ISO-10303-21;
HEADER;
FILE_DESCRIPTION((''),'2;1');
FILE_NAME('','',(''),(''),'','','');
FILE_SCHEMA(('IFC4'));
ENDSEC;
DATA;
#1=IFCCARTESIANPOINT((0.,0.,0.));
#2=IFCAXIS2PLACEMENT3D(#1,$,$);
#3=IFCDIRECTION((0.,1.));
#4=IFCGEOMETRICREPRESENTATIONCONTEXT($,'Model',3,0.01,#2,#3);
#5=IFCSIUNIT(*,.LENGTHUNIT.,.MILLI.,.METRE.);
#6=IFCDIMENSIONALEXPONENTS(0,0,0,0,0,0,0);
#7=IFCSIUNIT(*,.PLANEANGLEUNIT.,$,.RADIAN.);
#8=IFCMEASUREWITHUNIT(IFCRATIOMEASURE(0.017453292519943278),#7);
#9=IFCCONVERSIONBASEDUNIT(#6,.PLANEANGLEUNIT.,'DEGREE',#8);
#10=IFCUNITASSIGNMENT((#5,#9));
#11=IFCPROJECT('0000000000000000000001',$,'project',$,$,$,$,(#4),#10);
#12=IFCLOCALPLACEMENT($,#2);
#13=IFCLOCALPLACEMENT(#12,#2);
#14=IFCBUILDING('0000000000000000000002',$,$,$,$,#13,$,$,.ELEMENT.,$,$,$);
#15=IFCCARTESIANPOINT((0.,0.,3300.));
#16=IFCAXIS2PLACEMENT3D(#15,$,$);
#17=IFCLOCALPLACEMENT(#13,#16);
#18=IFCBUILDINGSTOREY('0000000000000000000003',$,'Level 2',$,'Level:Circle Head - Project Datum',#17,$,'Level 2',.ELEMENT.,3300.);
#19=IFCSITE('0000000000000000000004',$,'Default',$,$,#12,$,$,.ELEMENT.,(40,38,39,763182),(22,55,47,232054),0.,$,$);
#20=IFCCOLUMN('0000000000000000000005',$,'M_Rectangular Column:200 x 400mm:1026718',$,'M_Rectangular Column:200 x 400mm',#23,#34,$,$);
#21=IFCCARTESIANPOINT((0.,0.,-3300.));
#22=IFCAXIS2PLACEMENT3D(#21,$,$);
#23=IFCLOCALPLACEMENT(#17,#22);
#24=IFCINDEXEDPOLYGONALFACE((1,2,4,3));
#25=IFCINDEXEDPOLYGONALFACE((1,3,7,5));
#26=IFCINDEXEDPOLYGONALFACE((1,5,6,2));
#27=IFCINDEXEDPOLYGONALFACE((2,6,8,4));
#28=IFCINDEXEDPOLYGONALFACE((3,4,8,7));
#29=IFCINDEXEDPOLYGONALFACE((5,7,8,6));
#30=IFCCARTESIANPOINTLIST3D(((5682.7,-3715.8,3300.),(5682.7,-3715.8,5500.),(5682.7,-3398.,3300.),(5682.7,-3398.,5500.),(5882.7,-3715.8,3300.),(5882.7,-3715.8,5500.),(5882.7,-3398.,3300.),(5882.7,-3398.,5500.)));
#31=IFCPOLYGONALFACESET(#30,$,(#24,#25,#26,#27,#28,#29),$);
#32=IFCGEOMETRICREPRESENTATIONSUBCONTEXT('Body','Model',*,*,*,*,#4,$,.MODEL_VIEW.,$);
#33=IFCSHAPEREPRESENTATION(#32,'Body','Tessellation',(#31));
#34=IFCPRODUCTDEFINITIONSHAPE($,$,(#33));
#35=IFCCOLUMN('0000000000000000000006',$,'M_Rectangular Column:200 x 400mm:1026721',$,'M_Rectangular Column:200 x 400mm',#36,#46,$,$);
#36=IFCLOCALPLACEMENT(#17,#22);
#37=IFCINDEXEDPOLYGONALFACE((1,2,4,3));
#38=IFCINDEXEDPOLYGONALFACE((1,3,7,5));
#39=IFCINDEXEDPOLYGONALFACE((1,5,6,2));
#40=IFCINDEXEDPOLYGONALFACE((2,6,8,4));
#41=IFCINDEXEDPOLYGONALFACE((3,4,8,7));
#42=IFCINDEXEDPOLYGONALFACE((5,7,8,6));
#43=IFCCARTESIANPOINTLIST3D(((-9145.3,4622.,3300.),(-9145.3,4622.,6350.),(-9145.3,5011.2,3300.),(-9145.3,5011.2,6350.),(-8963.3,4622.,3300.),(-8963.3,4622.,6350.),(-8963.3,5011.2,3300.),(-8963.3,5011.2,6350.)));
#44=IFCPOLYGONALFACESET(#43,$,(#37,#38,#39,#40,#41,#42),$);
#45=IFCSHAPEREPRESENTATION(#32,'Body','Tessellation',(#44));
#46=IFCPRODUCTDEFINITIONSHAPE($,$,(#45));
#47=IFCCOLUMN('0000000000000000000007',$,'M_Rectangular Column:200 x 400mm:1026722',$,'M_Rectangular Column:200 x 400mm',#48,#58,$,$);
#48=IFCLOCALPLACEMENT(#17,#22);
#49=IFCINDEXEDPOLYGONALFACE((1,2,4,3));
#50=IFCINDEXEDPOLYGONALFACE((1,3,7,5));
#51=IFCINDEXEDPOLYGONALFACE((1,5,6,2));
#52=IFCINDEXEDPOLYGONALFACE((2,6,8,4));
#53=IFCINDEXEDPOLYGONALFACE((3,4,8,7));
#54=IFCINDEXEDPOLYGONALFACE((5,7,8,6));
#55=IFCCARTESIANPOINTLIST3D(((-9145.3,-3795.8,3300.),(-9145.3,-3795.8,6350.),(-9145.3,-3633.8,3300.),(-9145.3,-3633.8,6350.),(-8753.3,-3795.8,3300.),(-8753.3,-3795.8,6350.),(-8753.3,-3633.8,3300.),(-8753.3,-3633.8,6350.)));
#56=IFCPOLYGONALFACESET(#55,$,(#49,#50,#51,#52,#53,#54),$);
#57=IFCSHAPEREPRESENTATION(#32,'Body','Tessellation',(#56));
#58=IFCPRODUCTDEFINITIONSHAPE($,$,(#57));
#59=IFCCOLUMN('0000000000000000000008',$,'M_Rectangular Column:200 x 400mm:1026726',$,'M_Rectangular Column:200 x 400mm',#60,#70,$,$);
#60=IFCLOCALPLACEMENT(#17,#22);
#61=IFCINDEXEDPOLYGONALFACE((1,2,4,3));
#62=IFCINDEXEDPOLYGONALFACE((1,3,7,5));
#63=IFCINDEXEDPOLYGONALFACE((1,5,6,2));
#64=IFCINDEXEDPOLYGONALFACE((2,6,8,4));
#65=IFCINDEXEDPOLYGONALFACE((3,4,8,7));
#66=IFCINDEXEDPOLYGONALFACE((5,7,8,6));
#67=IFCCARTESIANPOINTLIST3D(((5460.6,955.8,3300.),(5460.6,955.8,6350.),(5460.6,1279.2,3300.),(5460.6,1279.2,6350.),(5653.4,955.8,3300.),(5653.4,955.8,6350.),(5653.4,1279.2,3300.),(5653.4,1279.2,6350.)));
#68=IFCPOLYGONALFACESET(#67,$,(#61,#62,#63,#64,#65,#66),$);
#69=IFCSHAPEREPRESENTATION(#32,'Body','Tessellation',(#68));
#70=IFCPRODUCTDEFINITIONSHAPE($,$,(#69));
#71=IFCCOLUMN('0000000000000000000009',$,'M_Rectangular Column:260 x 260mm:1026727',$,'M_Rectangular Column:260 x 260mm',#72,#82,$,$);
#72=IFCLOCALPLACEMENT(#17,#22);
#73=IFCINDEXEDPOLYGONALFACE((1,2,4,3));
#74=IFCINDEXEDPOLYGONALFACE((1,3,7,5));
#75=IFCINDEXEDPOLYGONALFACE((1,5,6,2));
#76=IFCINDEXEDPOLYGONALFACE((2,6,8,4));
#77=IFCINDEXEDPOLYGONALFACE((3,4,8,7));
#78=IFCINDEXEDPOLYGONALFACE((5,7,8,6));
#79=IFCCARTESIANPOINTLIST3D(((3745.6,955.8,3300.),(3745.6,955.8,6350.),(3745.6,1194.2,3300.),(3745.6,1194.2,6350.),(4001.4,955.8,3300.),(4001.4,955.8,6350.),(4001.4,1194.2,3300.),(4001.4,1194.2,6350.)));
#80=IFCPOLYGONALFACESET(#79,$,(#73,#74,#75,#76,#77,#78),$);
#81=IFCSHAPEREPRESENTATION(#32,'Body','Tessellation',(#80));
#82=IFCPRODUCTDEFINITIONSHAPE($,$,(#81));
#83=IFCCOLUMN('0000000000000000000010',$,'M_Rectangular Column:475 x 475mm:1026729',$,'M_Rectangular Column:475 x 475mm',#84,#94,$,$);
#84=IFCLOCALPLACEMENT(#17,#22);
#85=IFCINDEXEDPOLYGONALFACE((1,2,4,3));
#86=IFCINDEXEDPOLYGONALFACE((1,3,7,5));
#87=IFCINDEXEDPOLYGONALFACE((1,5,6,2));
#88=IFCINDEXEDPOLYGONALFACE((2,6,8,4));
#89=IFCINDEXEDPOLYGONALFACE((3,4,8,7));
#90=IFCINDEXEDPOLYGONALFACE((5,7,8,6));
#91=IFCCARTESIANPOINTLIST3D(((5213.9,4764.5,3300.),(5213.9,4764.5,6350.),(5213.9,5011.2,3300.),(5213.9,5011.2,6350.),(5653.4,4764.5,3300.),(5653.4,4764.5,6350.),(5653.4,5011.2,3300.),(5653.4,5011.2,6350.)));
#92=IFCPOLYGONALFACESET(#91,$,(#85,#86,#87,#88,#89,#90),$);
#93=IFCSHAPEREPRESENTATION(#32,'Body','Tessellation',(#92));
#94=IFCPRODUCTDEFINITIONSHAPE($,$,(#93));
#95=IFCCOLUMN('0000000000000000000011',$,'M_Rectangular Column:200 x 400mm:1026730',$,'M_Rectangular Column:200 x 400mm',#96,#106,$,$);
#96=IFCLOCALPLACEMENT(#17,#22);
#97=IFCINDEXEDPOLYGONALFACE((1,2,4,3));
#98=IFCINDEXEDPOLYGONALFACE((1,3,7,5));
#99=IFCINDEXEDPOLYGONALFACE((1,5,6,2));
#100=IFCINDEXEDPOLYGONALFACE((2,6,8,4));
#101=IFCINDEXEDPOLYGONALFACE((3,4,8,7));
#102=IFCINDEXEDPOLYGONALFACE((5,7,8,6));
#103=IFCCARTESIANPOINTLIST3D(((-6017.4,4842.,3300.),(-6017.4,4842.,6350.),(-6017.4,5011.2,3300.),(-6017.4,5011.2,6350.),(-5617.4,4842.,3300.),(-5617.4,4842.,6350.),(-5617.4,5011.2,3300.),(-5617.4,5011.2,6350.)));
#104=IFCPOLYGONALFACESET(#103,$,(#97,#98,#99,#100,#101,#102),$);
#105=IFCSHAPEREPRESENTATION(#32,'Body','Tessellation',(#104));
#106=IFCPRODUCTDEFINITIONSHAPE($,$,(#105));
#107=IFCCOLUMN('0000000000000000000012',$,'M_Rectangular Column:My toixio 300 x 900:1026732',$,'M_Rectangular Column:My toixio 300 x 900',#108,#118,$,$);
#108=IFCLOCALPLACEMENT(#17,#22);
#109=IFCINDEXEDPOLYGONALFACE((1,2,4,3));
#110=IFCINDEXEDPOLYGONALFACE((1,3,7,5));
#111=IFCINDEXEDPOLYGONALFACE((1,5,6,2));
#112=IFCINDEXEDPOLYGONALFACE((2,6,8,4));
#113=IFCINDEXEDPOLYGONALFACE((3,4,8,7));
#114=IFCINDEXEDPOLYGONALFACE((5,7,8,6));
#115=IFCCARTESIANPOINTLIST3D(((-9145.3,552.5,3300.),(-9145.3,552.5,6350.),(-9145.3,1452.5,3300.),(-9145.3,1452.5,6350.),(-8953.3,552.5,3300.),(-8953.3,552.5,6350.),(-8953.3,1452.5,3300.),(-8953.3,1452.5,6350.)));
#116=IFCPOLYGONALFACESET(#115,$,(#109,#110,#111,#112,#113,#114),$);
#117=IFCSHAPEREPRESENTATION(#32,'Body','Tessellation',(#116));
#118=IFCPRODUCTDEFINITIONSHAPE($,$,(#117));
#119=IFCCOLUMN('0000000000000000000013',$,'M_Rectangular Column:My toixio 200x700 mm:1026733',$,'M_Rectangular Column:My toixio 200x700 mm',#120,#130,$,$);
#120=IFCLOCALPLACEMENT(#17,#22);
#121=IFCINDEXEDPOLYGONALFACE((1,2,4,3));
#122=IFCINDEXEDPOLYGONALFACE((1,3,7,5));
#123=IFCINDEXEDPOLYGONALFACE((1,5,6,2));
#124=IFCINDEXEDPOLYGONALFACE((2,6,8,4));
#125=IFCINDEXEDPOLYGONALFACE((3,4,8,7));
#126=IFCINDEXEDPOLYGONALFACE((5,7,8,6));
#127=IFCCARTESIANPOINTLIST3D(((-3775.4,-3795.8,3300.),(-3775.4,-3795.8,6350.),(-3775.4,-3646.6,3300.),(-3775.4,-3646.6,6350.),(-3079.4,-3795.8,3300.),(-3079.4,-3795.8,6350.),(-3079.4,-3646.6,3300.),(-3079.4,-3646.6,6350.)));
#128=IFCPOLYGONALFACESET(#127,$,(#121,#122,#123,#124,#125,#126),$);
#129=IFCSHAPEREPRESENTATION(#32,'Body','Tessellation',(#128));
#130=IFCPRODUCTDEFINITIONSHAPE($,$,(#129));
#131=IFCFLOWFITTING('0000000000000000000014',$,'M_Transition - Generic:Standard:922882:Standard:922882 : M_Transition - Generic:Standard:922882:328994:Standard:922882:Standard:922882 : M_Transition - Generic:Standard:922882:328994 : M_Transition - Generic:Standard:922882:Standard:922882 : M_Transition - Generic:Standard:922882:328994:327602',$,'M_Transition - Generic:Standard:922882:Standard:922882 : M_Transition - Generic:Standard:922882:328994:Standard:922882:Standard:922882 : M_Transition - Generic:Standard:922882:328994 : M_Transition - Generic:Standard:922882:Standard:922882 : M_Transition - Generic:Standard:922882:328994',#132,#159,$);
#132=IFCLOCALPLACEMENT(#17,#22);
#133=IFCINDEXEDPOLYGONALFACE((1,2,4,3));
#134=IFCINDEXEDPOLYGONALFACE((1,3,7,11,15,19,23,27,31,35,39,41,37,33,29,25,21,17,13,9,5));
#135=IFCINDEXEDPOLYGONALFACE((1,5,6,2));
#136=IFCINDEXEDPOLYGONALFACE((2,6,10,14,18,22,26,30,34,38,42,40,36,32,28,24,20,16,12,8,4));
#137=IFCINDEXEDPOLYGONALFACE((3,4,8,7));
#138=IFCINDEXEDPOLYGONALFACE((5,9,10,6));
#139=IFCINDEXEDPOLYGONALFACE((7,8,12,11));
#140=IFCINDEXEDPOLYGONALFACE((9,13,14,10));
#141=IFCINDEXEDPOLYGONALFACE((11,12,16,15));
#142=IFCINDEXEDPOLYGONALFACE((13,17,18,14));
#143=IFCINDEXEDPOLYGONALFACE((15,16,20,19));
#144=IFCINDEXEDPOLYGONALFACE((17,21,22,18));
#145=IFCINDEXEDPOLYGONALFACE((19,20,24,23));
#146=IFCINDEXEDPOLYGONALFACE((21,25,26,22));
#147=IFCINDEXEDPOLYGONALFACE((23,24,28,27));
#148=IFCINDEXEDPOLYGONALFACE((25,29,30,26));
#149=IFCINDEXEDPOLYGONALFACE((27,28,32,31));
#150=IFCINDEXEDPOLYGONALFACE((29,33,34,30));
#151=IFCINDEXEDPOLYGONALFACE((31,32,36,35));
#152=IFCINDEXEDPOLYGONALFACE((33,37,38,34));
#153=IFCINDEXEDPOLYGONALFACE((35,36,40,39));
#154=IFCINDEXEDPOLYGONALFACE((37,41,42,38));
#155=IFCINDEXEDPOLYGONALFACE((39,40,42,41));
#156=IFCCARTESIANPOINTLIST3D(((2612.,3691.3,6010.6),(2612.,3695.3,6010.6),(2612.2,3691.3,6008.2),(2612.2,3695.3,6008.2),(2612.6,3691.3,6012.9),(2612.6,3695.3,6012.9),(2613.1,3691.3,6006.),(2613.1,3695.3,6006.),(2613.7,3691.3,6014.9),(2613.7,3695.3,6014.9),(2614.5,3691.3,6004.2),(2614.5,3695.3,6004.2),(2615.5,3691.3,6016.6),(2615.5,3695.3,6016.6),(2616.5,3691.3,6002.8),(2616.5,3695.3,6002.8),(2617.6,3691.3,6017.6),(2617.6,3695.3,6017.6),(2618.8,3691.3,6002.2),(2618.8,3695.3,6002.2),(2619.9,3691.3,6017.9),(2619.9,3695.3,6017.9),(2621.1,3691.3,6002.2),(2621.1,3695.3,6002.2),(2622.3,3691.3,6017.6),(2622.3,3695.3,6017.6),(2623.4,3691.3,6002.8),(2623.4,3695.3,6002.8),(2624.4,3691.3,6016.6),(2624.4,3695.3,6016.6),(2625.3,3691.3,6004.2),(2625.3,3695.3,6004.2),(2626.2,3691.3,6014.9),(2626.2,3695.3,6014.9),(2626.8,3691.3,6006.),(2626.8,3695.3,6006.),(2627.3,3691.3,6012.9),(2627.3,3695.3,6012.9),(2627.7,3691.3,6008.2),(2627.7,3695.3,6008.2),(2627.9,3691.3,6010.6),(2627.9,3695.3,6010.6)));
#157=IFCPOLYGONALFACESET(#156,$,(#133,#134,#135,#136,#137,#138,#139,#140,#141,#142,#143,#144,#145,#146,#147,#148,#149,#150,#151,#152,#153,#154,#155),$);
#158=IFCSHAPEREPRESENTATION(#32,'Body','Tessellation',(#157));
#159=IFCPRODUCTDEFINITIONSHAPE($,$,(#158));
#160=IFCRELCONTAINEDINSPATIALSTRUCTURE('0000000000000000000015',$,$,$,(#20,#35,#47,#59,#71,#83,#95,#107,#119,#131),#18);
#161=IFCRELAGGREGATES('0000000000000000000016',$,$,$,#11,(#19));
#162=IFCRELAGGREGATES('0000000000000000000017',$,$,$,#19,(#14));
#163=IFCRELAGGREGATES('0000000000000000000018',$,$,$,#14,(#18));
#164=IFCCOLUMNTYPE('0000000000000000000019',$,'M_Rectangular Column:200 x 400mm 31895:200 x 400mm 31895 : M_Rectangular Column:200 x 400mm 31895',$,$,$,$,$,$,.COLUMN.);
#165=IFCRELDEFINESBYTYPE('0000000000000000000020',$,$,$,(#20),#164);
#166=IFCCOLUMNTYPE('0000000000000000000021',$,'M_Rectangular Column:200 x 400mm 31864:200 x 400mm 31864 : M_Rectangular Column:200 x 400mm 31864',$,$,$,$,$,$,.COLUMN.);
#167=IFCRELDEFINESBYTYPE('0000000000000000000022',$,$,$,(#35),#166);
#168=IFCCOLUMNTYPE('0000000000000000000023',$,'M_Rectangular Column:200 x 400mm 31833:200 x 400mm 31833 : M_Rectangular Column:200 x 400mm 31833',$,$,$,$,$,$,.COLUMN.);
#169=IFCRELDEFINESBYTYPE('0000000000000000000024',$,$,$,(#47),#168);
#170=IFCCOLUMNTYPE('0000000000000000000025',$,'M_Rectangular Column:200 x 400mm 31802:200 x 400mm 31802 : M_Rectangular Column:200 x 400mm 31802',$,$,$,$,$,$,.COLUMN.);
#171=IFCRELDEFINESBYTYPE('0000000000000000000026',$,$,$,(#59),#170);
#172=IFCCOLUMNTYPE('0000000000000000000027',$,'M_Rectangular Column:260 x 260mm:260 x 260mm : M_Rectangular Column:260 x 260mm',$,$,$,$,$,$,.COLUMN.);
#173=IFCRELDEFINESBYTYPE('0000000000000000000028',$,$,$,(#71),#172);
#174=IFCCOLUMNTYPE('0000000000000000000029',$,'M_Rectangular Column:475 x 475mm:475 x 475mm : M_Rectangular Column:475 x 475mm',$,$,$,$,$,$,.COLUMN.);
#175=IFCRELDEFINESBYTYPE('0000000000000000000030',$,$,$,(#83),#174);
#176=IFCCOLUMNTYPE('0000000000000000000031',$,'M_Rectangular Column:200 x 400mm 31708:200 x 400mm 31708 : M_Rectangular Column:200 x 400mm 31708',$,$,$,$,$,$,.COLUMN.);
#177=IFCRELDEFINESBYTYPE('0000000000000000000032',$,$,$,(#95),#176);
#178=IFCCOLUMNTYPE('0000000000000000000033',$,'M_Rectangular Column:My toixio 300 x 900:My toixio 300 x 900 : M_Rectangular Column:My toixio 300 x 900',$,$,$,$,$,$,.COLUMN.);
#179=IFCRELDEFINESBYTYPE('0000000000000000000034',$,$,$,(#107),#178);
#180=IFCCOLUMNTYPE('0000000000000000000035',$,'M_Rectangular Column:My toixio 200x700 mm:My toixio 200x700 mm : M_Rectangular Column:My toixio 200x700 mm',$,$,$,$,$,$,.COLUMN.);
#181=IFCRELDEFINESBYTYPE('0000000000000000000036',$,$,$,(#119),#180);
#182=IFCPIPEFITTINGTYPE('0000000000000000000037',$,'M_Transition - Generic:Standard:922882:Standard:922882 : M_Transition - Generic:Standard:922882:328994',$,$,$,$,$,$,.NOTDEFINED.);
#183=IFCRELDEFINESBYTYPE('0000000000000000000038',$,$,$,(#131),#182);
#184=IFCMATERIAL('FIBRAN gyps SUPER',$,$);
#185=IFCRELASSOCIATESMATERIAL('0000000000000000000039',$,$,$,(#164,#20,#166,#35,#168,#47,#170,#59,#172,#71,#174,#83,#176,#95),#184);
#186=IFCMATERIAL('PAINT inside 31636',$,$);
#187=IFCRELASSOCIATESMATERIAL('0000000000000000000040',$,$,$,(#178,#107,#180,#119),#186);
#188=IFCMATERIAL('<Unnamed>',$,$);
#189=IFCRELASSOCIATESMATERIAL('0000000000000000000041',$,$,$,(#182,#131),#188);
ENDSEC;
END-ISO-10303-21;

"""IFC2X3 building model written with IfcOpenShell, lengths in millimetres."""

from ifc_helpers import new_model, entity, si_unit, converted_unit, direction, frame, frame_2d, origin, origin_2d_with_axis, place, context, subcontext, project, spatial, rectangle, circle, extrude, source, transform, mapped, material, type_object, type_shapes, element, save


model = new_model("IFC2X3")

# Units and contexts
model_context = context("Model", 3, precision=0.01, world=origin(), true_north=direction((0.0, 1.0)))
body_context = subcontext(model_context, "Body", "Model", "MODEL_VIEW")
ifc_project = project(units=[si_unit("LENGTHUNIT", "METRE", prefix="MILLI"), converted_unit("PLANEANGLEUNIT", "DEGREE", entity("IfcRatioMeasure", 0.017453292519943278), si_unit("PLANEANGLEUNIT", "RADIAN"), dimensions=[0, 0, 0, 0, 0, 0, 0])], contexts=[model_context])

# Site, building, storey
site_placement = place(None, origin())
site = spatial("IfcSite", under=ifc_project, at=site_placement, Name="Default", CompositionType="ELEMENT", RefLatitude=(40, 38, 39, 763182), RefLongitude=(22, 55, 47, 232054), RefElevation=0.0)
building_placement = place(site_placement, origin())
building = spatial("IfcBuilding", under=site, at=building_placement, CompositionType="ELEMENT")
storey_placement = place(building_placement, frame((0.0, 0.0, 3300.0)))
storey = spatial("IfcBuildingStorey", under=building, at=storey_placement, Name="Level 2", ObjectType="Level:Circle Head - Project Datum", LongName="Level 2", CompositionType="ELEMENT", Elevation=3300.0)

# Columns
ifc_material_1 = material(Name="FIBRAN gyps SUPER")
column_type_1 = type_object("IfcColumnType", Name="M_Rectangular Column:200 x 400mm 31895:200 x 400mm 31895 : M_Rectangular Column:200 x 400mm 31895", PredefinedType="COLUMN", material=ifc_material_1)
shared_shape_1 = source(origin(), body_context, "Body", "SweptSolid", [
    extrude(rectangle(XDim=317.9, YDim=200.0, at=frame_2d((0.0, 0.0), x_axis=(1.0, 0.0))), frame((5782.7, -3556.9, 3300.0), z_axis=(0.0, 0.0, 1.0), x_axis=(0.0, -1.0, 0.0)), (0.0, 0.0, 1.0), 2200.0),
])
type_shapes(column_type_1, [shared_shape_1])
column_1_placement = place(storey_placement, frame((0.0, 0.0, -3300.0)))
element("IfcColumn", 1, at=column_1_placement, inside=storey, type_object=column_type_1, material=ifc_material_1, Name="M_Rectangular Column:200 x 400mm:1026718", ObjectType="M_Rectangular Column:200 x 400mm", context=body_context, shape_type="MappedRepresentation", body=[
    mapped(shared_shape_1, transform((0.0, 0.0, 0.0), scale=1.0)),
])
column_type_2 = type_object("IfcColumnType", Name="M_Rectangular Column:200 x 400mm 31864:200 x 400mm 31864 : M_Rectangular Column:200 x 400mm 31864", PredefinedType="COLUMN", material=ifc_material_1)
shared_shape_2 = source(origin(), body_context, "Body", "SweptSolid", [
    extrude(rectangle(XDim=389.1, YDim=182.0, at=frame_2d((0.0, 0.0), x_axis=(1.0, 0.0))), frame((-9054.3, 4816.6, 3300.0), z_axis=(0.0, 0.0, 1.0), x_axis=(0.0, -1.0, 0.0)), (0.0, 0.0, 1.0), 3050.0),
])
type_shapes(column_type_2, [shared_shape_2])
column_2_placement = place(storey_placement, frame((0.0, 0.0, -3300.0)))
element("IfcColumn", 2, at=column_2_placement, inside=storey, type_object=column_type_2, material=ifc_material_1, Name="M_Rectangular Column:200 x 400mm:1026721", ObjectType="M_Rectangular Column:200 x 400mm", context=body_context, shape_type="MappedRepresentation", body=[
    mapped(shared_shape_2, transform((0.0, 0.0, 0.0), scale=1.0)),
])
column_type_3 = type_object("IfcColumnType", Name="M_Rectangular Column:200 x 400mm 31833:200 x 400mm 31833 : M_Rectangular Column:200 x 400mm 31833", PredefinedType="COLUMN", material=ifc_material_1)
shared_shape_3 = source(origin(), body_context, "Body", "SweptSolid", [
    extrude(rectangle(XDim=162.0, YDim=392.0, at=frame_2d((0.0, 0.0), x_axis=(1.0, 0.0))), frame((-8949.3, -3714.8, 3300.0), z_axis=(0.0, 0.0, 1.0), x_axis=(0.0, -1.0, 0.0)), (0.0, 0.0, 1.0), 3050.0),
])
type_shapes(column_type_3, [shared_shape_3])
column_3_placement = place(storey_placement, frame((0.0, 0.0, -3300.0)))
element("IfcColumn", 3, at=column_3_placement, inside=storey, type_object=column_type_3, material=ifc_material_1, Name="M_Rectangular Column:200 x 400mm:1026722", ObjectType="M_Rectangular Column:200 x 400mm", context=body_context, shape_type="MappedRepresentation", body=[
    mapped(shared_shape_3, transform((0.0, 0.0, 0.0), scale=1.0)),
])
column_type_4 = type_object("IfcColumnType", Name="M_Rectangular Column:200 x 400mm 31802:200 x 400mm 31802 : M_Rectangular Column:200 x 400mm 31802", PredefinedType="COLUMN", material=ifc_material_1)
shared_shape_4 = source(origin(), body_context, "Body", "SweptSolid", [
    extrude(rectangle(XDim=323.4, YDim=192.8, at=frame_2d((0.0, 0.0), x_axis=(1.0, 0.0))), frame((5557.0, 1117.5, 3300.0), z_axis=(0.0, 0.0, 1.0), x_axis=(0.0, -1.0, 0.0)), (0.0, 0.0, 1.0), 3050.0),
])
type_shapes(column_type_4, [shared_shape_4])
column_4_placement = place(storey_placement, frame((0.0, 0.0, -3300.0)))
element("IfcColumn", 4, at=column_4_placement, inside=storey, type_object=column_type_4, material=ifc_material_1, Name="M_Rectangular Column:200 x 400mm:1026726", ObjectType="M_Rectangular Column:200 x 400mm", context=body_context, shape_type="MappedRepresentation", body=[
    mapped(shared_shape_4, transform((0.0, 0.0, 0.0), scale=1.0)),
])
column_type_5 = type_object("IfcColumnType", Name="M_Rectangular Column:260 x 260mm:260 x 260mm : M_Rectangular Column:260 x 260mm", PredefinedType="COLUMN", material=ifc_material_1)
shared_shape_5 = source(origin(), body_context, "Body", "SweptSolid", [
    extrude(rectangle(XDim=238.4, YDim=255.8, at=frame_2d((0.0, 0.0), x_axis=(1.0, 0.0))), frame((3873.5, 1075.0, 3300.0), z_axis=(0.0, 0.0, 1.0), x_axis=(0.0, -1.0, 0.0)), (0.0, 0.0, 1.0), 3050.0),
])
type_shapes(column_type_5, [shared_shape_5])
column_5_placement = place(storey_placement, frame((0.0, 0.0, -3300.0)))
element("IfcColumn", 5, at=column_5_placement, inside=storey, type_object=column_type_5, material=ifc_material_1, Name="M_Rectangular Column:260 x 260mm:1026727", ObjectType="M_Rectangular Column:260 x 260mm", context=body_context, shape_type="MappedRepresentation", body=[
    mapped(shared_shape_5, transform((0.0, 0.0, 0.0), scale=1.0)),
])
column_type_6 = type_object("IfcColumnType", Name="M_Rectangular Column:475 x 475mm:475 x 475mm : M_Rectangular Column:475 x 475mm", PredefinedType="COLUMN", material=ifc_material_1)
shared_shape_6 = source(origin(), body_context, "Body", "SweptSolid", [
    extrude(rectangle(XDim=246.6, YDim=439.5, at=frame_2d((0.0, 0.0), x_axis=(1.0, 0.0))), frame((5433.6, 4887.8, 3300.0), z_axis=(0.0, 0.0, 1.0), x_axis=(0.0, -1.0, 0.0)), (0.0, 0.0, 1.0), 3050.0),
])
type_shapes(column_type_6, [shared_shape_6])
column_6_placement = place(storey_placement, frame((0.0, 0.0, -3300.0)))
element("IfcColumn", 6, at=column_6_placement, inside=storey, type_object=column_type_6, material=ifc_material_1, Name="M_Rectangular Column:475 x 475mm:1026729", ObjectType="M_Rectangular Column:475 x 475mm", context=body_context, shape_type="MappedRepresentation", body=[
    mapped(shared_shape_6, transform((0.0, 0.0, 0.0), scale=1.0)),
])
column_type_7 = type_object("IfcColumnType", Name="M_Rectangular Column:200 x 400mm 31708:200 x 400mm 31708 : M_Rectangular Column:200 x 400mm 31708", PredefinedType="COLUMN", material=ifc_material_1)
shared_shape_7 = source(origin(), body_context, "Body", "SweptSolid", [
    extrude(rectangle(XDim=169.1, YDim=400.0, at=frame_2d((0.0, 0.0), x_axis=(1.0, 0.0))), frame((-5817.4, 4926.6, 3300.0), z_axis=(0.0, 0.0, 1.0), x_axis=(0.0, -1.0, 0.0)), (0.0, 0.0, 1.0), 3050.0),
])
type_shapes(column_type_7, [shared_shape_7])
column_7_placement = place(storey_placement, frame((0.0, 0.0, -3300.0)))
element("IfcColumn", 7, at=column_7_placement, inside=storey, type_object=column_type_7, material=ifc_material_1, Name="M_Rectangular Column:200 x 400mm:1026730", ObjectType="M_Rectangular Column:200 x 400mm", context=body_context, shape_type="MappedRepresentation", body=[
    mapped(shared_shape_7, transform((0.0, 0.0, 0.0), scale=1.0)),
])
ifc_material_2 = material(Name="PAINT inside 31636")
column_type_8 = type_object("IfcColumnType", Name="M_Rectangular Column:My toixio 300 x 900:My toixio 300 x 900 : M_Rectangular Column:My toixio 300 x 900", PredefinedType="COLUMN", material=ifc_material_2)
shared_shape_8 = source(origin(), body_context, "Body", "SweptSolid", [
    extrude(rectangle(XDim=900.0, YDim=192.0, at=origin_2d_with_axis()), frame((-9049.3, 1002.5, 3300.0), z_axis=(0.0, 0.0, 1.0), x_axis=(0.0, -1.0, 0.0)), (0.0, 0.0, 1.0), 3050.0),
])
type_shapes(column_type_8, [shared_shape_8])
column_8_placement = place(storey_placement, frame((0.0, 0.0, -3300.0)))
element("IfcColumn", 8, at=column_8_placement, inside=storey, type_object=column_type_8, material=ifc_material_2, Name="M_Rectangular Column:My toixio 300 x 900:1026732", ObjectType="M_Rectangular Column:My toixio 300 x 900", context=body_context, shape_type="MappedRepresentation", body=[
    mapped(shared_shape_8, transform((0.0, 0.0, 0.0), scale=1.0)),
])
column_type_9 = type_object("IfcColumnType", Name="M_Rectangular Column:My toixio 200x700 mm:My toixio 200x700 mm : M_Rectangular Column:My toixio 200x700 mm", PredefinedType="COLUMN", material=ifc_material_2)
shared_shape_9 = source(origin(), body_context, "Body", "SweptSolid", [
    extrude(rectangle(XDim=149.2, YDim=696.0, at=origin_2d_with_axis()), frame((-3427.4, -3721.2, 3300.0), z_axis=(0.0, 0.0, 1.0), x_axis=(0.0, -1.0, 0.0)), (0.0, 0.0, 1.0), 3050.0),
])
type_shapes(column_type_9, [shared_shape_9])
column_9_placement = place(storey_placement, frame((0.0, 0.0, -3300.0)))
element("IfcColumn", 9, at=column_9_placement, inside=storey, type_object=column_type_9, material=ifc_material_2, Name="M_Rectangular Column:My toixio 200x700 mm:1026733", ObjectType="M_Rectangular Column:My toixio 200x700 mm", context=body_context, shape_type="MappedRepresentation", body=[
    mapped(shared_shape_9, transform((0.0, 0.0, 0.0), scale=1.0)),
])

# Flow fitting
ifc_material_3 = material(Name="<Unnamed>")
pipe_fitting_type = type_object("IfcPipeFittingType", Name="M_Transition - Generic:Standard:922882:Standard:922882 : M_Transition - Generic:Standard:922882:328994", PredefinedType="NOTDEFINED", material=ifc_material_3)
shared_shape_10 = source(origin(), body_context, "Body", "SweptSolid", [
    extrude(circle(Radius=7.9, at=origin_2d_with_axis()), frame((2619.9, 3691.3, 6010.0), z_axis=(0.0, 1.0, 0.0), x_axis=(0.0, 0.0, 1.0)), (0.0, 0.0, 1.0), 4.0),
])
type_shapes(pipe_fitting_type, [shared_shape_10])
flow_fitting_placement = place(storey_placement, frame((0.0, 0.0, -3300.0)))
element("IfcFlowFitting", 10, at=flow_fitting_placement, inside=storey, type_object=pipe_fitting_type, material=ifc_material_3, Name="M_Transition - Generic:Standard:922882:Standard:922882 : M_Transition - Generic:Standard:922882:328994:Standard:922882:Standard:922882 : M_Transition - Generic:Standard:922882:328994 : M_Transition - Generic:Standard:922882:Standard:922882 : M_Transition - Generic:Standard:922882:328994:327602", ObjectType="M_Transition - Generic:Standard:922882:Standard:922882 : M_Transition - Generic:Standard:922882:328994:Standard:922882:Standard:922882 : M_Transition - Generic:Standard:922882:328994 : M_Transition - Generic:Standard:922882:Standard:922882 : M_Transition - Generic:Standard:922882:328994", context=body_context, shape_type="MappedRepresentation", body=[
    mapped(shared_shape_10, transform((0.0, 0.0, 0.0), scale=1.0)),
])

save(model, "model.ifc")
